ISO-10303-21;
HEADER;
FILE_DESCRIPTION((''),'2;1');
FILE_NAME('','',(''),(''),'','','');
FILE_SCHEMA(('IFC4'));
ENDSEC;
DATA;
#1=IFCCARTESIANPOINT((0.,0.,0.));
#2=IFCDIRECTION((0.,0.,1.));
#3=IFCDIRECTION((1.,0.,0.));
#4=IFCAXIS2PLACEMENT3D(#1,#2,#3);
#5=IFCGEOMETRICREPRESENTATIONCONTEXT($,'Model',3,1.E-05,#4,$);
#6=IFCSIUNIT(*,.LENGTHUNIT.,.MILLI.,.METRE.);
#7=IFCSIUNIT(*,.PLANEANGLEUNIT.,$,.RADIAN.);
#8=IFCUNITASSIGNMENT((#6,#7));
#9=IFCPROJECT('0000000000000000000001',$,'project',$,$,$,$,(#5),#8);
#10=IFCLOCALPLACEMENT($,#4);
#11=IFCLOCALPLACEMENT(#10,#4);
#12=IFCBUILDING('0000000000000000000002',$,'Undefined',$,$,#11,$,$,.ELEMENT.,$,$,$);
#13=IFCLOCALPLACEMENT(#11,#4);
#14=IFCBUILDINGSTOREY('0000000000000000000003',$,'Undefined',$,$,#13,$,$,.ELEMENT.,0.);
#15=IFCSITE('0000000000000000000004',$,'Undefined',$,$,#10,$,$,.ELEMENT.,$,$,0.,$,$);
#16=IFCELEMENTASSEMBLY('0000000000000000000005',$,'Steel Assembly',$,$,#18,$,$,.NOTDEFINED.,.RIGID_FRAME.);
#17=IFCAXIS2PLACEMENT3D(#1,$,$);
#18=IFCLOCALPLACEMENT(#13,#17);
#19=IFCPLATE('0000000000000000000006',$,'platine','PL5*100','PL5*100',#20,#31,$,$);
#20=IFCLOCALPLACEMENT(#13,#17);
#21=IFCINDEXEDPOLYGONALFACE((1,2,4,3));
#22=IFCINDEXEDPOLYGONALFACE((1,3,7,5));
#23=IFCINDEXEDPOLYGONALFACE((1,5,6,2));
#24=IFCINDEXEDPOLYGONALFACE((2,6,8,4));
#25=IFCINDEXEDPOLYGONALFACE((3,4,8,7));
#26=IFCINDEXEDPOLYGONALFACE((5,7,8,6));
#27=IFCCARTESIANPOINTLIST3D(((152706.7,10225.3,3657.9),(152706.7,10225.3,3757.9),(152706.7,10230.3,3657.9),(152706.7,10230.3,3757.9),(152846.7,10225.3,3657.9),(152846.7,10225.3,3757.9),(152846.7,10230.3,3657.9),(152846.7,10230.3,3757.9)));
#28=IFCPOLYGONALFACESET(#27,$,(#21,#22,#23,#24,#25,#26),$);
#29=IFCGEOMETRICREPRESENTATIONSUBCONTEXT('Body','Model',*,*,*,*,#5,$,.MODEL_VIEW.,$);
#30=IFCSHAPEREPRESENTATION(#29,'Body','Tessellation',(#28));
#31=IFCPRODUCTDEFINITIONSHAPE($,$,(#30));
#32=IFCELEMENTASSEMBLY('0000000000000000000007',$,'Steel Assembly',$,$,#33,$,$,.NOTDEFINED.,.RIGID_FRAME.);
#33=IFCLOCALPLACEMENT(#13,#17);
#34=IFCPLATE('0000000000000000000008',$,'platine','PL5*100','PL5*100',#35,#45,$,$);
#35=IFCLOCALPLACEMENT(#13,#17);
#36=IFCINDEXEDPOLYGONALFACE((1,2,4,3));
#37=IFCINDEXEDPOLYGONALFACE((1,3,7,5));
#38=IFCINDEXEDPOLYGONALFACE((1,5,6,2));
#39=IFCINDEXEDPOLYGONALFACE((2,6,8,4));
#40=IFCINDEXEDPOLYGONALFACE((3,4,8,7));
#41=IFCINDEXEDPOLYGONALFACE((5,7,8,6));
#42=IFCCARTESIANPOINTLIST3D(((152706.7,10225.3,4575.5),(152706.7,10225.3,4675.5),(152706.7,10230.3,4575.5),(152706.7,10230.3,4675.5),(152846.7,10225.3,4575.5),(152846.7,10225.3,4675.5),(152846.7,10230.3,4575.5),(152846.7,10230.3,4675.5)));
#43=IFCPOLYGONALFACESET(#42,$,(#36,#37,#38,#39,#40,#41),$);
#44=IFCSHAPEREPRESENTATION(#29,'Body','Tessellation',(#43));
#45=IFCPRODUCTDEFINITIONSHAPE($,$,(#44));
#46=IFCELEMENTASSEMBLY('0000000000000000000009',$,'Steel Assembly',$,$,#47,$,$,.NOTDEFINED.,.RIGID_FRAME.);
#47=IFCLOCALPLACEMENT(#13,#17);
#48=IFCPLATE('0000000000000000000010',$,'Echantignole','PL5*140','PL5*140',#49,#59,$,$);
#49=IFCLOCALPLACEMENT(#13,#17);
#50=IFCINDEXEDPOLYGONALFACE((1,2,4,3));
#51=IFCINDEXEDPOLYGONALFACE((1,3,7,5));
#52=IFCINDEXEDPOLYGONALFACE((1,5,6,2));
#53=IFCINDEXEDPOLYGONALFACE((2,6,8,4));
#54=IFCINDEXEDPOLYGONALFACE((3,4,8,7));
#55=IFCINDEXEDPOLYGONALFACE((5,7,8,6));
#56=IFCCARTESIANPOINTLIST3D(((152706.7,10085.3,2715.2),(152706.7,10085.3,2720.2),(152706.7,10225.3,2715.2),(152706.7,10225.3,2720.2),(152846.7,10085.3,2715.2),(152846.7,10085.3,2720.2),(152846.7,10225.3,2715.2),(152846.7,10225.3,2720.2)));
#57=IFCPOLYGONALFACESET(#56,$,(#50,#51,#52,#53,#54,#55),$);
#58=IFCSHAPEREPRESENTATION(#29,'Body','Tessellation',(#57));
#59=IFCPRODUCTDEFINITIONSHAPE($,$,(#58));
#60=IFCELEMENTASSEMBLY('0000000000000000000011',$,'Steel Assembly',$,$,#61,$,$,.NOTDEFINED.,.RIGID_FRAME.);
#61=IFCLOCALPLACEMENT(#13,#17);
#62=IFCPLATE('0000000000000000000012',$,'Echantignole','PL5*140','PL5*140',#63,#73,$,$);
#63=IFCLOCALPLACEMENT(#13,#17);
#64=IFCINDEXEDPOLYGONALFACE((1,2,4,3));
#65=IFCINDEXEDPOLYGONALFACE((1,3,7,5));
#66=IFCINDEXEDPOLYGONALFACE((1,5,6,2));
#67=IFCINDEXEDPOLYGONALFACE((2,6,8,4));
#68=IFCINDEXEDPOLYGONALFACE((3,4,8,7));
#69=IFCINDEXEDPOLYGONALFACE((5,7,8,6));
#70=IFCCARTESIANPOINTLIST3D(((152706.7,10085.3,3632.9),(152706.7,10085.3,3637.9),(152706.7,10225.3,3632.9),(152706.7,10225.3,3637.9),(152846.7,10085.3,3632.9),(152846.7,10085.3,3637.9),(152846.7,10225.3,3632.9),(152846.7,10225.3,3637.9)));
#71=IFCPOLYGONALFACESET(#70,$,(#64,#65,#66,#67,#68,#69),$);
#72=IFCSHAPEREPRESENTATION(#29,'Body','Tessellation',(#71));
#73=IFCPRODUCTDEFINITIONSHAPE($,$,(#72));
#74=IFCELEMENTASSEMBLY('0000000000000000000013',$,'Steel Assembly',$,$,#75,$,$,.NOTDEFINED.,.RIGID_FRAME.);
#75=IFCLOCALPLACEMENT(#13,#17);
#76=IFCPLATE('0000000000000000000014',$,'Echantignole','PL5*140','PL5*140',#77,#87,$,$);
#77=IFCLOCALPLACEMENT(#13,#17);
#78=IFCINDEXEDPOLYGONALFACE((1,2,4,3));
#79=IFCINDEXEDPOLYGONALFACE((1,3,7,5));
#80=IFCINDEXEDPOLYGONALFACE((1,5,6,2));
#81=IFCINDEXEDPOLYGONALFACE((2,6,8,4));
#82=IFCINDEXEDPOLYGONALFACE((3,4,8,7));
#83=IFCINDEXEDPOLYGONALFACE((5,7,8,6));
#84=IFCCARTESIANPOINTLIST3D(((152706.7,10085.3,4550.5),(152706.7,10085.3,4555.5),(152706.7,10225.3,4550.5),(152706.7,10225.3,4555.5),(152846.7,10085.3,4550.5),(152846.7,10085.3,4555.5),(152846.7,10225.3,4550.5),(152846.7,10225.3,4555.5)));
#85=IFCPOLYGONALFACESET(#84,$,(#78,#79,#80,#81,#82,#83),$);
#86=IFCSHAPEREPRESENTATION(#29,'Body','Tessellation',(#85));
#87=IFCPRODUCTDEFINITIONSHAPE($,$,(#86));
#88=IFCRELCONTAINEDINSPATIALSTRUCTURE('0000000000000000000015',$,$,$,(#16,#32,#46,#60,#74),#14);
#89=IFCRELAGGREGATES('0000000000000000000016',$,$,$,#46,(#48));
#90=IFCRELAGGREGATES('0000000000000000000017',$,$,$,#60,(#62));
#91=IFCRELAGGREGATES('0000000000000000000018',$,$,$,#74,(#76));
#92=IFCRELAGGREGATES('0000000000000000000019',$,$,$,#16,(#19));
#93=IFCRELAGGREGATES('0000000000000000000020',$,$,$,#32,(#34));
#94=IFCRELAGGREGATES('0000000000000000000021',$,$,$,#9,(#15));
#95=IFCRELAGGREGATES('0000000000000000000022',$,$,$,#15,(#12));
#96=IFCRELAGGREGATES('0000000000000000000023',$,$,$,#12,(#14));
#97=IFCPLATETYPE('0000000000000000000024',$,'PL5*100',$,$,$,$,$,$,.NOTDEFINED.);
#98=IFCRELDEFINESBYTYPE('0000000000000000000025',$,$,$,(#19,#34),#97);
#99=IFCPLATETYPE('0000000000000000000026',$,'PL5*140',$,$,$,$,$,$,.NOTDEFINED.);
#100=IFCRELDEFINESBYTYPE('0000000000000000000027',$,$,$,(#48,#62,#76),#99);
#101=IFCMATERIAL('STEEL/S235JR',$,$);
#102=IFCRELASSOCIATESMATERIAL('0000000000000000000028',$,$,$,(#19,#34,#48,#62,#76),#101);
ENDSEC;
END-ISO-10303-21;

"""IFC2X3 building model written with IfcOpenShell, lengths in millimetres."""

from ifc_helpers import new_model, si_unit, frame, origin_with_axes, place, context, subcontext, project, spatial, polyline, outline, extrude, material, type_object, element, aggregate, save


model = new_model("IFC2X3")

# Units and contexts
model_context = context("Model", 3, precision=1e-05, world=origin_with_axes())
body_context = subcontext(model_context, "Body", "Model", "MODEL_VIEW")
ifc_project = project(units=[si_unit("LENGTHUNIT", "METRE", prefix="MILLI"), si_unit("PLANEANGLEUNIT", "RADIAN")], contexts=[model_context])

# Site, building, storey
site_placement = place(None, origin_with_axes())
site = spatial("IfcSite", under=ifc_project, at=site_placement, Name="Undefined", CompositionType="ELEMENT", RefElevation=0.0)
building_placement = place(site_placement, origin_with_axes())
building = spatial("IfcBuilding", under=site, at=building_placement, Name="Undefined", CompositionType="ELEMENT")
storey_placement = place(building_placement, origin_with_axes())
storey = spatial("IfcBuildingStorey", under=building, at=storey_placement, Name="Undefined", CompositionType="ELEMENT", Elevation=0.0)

# Shared definitions
ifc_material_1 = material(Name="STEEL/S235JR")

# Element assemblies, plates
plate_type_1 = type_object("IfcPlateType", Name="PL5*100", PredefinedType="NOTDEFINED")
assembly_1_placement = place(storey_placement, origin_with_axes())
assembly_1 = element("IfcElementAssembly", 1, at=assembly_1_placement, inside=storey, Name="Steel Assembly", AssemblyPlace="NOTDEFINED", PredefinedType="RIGID_FRAME")
plate_1_placement = place(assembly_1_placement, frame((152846.7, 10227.8, 3757.9), z_axis=(0.0, -1.0, 0.0), x_axis=(-1.0, 0.0, 0.0)))
plate_1 = element("IfcPlate", 2, at=plate_1_placement, type_object=plate_type_1, material=ifc_material_1, Name="platine", Description="PL5*100", ObjectType="PL5*100", context=body_context, shape_type="SweptSolid", body=[
    extrude(outline(polyline([(0.0, 0.0), (140.0, 0.0), (140.0, 100.0), (0.0, 100.0), (0.0, 0.0)])), frame((0.0, 0.0, -2.5), z_axis=(0.0, 0.0, 1.0), x_axis=(1.0, 0.0, 0.0)), (0.0, 0.0, 1.0), 5.0),
])
assembly_2_placement = place(storey_placement, origin_with_axes())
assembly_2 = element("IfcElementAssembly", 3, at=assembly_2_placement, inside=storey, Name="Steel Assembly", AssemblyPlace="NOTDEFINED", PredefinedType="RIGID_FRAME")
plate_2_placement = place(assembly_2_placement, frame((152846.7, 10227.8, 4675.5), z_axis=(0.0, -1.0, 0.0), x_axis=(-1.0, 0.0, 0.0)))
plate_2 = element("IfcPlate", 4, at=plate_2_placement, type_object=plate_type_1, material=ifc_material_1, Name="platine", Description="PL5*100", ObjectType="PL5*100", context=body_context, shape_type="SweptSolid", body=[
    extrude(outline(polyline([(0.0, 0.0), (140.0, 0.0), (140.0, 100.0), (0.0, 100.0), (0.0, 0.0)])), frame((0.0, 0.0, -2.5), z_axis=(0.0, 0.0, 1.0), x_axis=(1.0, 0.0, 0.0)), (0.0, 0.0, 1.0), 5.0),
])
assembly_3_placement = place(storey_placement, origin_with_axes())
assembly_3 = element("IfcElementAssembly", 5, at=assembly_3_placement, inside=storey, Name="Steel Assembly", AssemblyPlace="NOTDEFINED", PredefinedType="RIGID_FRAME")
plate_type_2 = type_object("IfcPlateType", Name="PL5*140", PredefinedType="NOTDEFINED")
plate_3_placement = place(assembly_3_placement, frame((152846.7, 10225.3, 2717.7), z_axis=(0.0, 0.0, 1.0), x_axis=(-1.0, 0.0, 0.0)))
plate_3 = element("IfcPlate", 6, at=plate_3_placement, type_object=plate_type_2, material=ifc_material_1, Name="Echantignole", Description="PL5*140", ObjectType="PL5*140", context=body_context, shape_type="SweptSolid", body=[
    extrude(outline(polyline([(0.0, 0.0), (140.0, 0.0), (140.0, 140.0), (0.0, 140.0), (0.0, 0.0)])), frame((0.0, 0.0, -2.5), z_axis=(0.0, 0.0, 1.0), x_axis=(1.0, 0.0, 0.0)), (0.0, 0.0, 1.0), 5.0),
])
aggregate(assembly_3, [plate_3])
assembly_4_placement = place(storey_placement, origin_with_axes())
assembly_4 = element("IfcElementAssembly", 7, at=assembly_4_placement, inside=storey, Name="Steel Assembly", AssemblyPlace="NOTDEFINED", PredefinedType="RIGID_FRAME")
plate_4_placement = place(assembly_4_placement, frame((152846.7, 10225.3, 3635.4), z_axis=(0.0, 0.0, 1.0), x_axis=(-1.0, 0.0, 0.0)))
plate_4 = element("IfcPlate", 8, at=plate_4_placement, type_object=plate_type_2, material=ifc_material_1, Name="Echantignole", Description="PL5*140", ObjectType="PL5*140", context=body_context, shape_type="SweptSolid", body=[
    extrude(outline(polyline([(0.0, 0.0), (140.0, 0.0), (140.0, 140.0), (0.0, 140.0), (0.0, 0.0)])), frame((0.0, 0.0, -2.5), z_axis=(0.0, 0.0, 1.0), x_axis=(1.0, 0.0, 0.0)), (0.0, 0.0, 1.0), 5.0),
])
aggregate(assembly_4, [plate_4])
assembly_5_placement = place(storey_placement, origin_with_axes())
assembly_5 = element("IfcElementAssembly", 9, at=assembly_5_placement, inside=storey, Name="Steel Assembly", AssemblyPlace="NOTDEFINED", PredefinedType="RIGID_FRAME")
plate_5_placement = place(assembly_5_placement, frame((152846.7, 10225.3, 4553.0), z_axis=(0.0, 0.0, 1.0), x_axis=(-1.0, 0.0, 0.0)))
plate_5 = element("IfcPlate", 10, at=plate_5_placement, type_object=plate_type_2, material=ifc_material_1, Name="Echantignole", Description="PL5*140", ObjectType="PL5*140", context=body_context, shape_type="SweptSolid", body=[
    extrude(outline(polyline([(0.0, 0.0), (140.0, 0.0), (140.0, 140.0), (0.0, 140.0), (0.0, 0.0)])), frame((0.0, 0.0, -2.5), z_axis=(0.0, 0.0, 1.0), x_axis=(1.0, 0.0, 0.0)), (0.0, 0.0, 1.0), 5.0),
])
aggregate(assembly_5, [plate_5])

aggregate(assembly_1, [plate_1])
aggregate(assembly_2, [plate_2])

save(model, "model.ifc")
